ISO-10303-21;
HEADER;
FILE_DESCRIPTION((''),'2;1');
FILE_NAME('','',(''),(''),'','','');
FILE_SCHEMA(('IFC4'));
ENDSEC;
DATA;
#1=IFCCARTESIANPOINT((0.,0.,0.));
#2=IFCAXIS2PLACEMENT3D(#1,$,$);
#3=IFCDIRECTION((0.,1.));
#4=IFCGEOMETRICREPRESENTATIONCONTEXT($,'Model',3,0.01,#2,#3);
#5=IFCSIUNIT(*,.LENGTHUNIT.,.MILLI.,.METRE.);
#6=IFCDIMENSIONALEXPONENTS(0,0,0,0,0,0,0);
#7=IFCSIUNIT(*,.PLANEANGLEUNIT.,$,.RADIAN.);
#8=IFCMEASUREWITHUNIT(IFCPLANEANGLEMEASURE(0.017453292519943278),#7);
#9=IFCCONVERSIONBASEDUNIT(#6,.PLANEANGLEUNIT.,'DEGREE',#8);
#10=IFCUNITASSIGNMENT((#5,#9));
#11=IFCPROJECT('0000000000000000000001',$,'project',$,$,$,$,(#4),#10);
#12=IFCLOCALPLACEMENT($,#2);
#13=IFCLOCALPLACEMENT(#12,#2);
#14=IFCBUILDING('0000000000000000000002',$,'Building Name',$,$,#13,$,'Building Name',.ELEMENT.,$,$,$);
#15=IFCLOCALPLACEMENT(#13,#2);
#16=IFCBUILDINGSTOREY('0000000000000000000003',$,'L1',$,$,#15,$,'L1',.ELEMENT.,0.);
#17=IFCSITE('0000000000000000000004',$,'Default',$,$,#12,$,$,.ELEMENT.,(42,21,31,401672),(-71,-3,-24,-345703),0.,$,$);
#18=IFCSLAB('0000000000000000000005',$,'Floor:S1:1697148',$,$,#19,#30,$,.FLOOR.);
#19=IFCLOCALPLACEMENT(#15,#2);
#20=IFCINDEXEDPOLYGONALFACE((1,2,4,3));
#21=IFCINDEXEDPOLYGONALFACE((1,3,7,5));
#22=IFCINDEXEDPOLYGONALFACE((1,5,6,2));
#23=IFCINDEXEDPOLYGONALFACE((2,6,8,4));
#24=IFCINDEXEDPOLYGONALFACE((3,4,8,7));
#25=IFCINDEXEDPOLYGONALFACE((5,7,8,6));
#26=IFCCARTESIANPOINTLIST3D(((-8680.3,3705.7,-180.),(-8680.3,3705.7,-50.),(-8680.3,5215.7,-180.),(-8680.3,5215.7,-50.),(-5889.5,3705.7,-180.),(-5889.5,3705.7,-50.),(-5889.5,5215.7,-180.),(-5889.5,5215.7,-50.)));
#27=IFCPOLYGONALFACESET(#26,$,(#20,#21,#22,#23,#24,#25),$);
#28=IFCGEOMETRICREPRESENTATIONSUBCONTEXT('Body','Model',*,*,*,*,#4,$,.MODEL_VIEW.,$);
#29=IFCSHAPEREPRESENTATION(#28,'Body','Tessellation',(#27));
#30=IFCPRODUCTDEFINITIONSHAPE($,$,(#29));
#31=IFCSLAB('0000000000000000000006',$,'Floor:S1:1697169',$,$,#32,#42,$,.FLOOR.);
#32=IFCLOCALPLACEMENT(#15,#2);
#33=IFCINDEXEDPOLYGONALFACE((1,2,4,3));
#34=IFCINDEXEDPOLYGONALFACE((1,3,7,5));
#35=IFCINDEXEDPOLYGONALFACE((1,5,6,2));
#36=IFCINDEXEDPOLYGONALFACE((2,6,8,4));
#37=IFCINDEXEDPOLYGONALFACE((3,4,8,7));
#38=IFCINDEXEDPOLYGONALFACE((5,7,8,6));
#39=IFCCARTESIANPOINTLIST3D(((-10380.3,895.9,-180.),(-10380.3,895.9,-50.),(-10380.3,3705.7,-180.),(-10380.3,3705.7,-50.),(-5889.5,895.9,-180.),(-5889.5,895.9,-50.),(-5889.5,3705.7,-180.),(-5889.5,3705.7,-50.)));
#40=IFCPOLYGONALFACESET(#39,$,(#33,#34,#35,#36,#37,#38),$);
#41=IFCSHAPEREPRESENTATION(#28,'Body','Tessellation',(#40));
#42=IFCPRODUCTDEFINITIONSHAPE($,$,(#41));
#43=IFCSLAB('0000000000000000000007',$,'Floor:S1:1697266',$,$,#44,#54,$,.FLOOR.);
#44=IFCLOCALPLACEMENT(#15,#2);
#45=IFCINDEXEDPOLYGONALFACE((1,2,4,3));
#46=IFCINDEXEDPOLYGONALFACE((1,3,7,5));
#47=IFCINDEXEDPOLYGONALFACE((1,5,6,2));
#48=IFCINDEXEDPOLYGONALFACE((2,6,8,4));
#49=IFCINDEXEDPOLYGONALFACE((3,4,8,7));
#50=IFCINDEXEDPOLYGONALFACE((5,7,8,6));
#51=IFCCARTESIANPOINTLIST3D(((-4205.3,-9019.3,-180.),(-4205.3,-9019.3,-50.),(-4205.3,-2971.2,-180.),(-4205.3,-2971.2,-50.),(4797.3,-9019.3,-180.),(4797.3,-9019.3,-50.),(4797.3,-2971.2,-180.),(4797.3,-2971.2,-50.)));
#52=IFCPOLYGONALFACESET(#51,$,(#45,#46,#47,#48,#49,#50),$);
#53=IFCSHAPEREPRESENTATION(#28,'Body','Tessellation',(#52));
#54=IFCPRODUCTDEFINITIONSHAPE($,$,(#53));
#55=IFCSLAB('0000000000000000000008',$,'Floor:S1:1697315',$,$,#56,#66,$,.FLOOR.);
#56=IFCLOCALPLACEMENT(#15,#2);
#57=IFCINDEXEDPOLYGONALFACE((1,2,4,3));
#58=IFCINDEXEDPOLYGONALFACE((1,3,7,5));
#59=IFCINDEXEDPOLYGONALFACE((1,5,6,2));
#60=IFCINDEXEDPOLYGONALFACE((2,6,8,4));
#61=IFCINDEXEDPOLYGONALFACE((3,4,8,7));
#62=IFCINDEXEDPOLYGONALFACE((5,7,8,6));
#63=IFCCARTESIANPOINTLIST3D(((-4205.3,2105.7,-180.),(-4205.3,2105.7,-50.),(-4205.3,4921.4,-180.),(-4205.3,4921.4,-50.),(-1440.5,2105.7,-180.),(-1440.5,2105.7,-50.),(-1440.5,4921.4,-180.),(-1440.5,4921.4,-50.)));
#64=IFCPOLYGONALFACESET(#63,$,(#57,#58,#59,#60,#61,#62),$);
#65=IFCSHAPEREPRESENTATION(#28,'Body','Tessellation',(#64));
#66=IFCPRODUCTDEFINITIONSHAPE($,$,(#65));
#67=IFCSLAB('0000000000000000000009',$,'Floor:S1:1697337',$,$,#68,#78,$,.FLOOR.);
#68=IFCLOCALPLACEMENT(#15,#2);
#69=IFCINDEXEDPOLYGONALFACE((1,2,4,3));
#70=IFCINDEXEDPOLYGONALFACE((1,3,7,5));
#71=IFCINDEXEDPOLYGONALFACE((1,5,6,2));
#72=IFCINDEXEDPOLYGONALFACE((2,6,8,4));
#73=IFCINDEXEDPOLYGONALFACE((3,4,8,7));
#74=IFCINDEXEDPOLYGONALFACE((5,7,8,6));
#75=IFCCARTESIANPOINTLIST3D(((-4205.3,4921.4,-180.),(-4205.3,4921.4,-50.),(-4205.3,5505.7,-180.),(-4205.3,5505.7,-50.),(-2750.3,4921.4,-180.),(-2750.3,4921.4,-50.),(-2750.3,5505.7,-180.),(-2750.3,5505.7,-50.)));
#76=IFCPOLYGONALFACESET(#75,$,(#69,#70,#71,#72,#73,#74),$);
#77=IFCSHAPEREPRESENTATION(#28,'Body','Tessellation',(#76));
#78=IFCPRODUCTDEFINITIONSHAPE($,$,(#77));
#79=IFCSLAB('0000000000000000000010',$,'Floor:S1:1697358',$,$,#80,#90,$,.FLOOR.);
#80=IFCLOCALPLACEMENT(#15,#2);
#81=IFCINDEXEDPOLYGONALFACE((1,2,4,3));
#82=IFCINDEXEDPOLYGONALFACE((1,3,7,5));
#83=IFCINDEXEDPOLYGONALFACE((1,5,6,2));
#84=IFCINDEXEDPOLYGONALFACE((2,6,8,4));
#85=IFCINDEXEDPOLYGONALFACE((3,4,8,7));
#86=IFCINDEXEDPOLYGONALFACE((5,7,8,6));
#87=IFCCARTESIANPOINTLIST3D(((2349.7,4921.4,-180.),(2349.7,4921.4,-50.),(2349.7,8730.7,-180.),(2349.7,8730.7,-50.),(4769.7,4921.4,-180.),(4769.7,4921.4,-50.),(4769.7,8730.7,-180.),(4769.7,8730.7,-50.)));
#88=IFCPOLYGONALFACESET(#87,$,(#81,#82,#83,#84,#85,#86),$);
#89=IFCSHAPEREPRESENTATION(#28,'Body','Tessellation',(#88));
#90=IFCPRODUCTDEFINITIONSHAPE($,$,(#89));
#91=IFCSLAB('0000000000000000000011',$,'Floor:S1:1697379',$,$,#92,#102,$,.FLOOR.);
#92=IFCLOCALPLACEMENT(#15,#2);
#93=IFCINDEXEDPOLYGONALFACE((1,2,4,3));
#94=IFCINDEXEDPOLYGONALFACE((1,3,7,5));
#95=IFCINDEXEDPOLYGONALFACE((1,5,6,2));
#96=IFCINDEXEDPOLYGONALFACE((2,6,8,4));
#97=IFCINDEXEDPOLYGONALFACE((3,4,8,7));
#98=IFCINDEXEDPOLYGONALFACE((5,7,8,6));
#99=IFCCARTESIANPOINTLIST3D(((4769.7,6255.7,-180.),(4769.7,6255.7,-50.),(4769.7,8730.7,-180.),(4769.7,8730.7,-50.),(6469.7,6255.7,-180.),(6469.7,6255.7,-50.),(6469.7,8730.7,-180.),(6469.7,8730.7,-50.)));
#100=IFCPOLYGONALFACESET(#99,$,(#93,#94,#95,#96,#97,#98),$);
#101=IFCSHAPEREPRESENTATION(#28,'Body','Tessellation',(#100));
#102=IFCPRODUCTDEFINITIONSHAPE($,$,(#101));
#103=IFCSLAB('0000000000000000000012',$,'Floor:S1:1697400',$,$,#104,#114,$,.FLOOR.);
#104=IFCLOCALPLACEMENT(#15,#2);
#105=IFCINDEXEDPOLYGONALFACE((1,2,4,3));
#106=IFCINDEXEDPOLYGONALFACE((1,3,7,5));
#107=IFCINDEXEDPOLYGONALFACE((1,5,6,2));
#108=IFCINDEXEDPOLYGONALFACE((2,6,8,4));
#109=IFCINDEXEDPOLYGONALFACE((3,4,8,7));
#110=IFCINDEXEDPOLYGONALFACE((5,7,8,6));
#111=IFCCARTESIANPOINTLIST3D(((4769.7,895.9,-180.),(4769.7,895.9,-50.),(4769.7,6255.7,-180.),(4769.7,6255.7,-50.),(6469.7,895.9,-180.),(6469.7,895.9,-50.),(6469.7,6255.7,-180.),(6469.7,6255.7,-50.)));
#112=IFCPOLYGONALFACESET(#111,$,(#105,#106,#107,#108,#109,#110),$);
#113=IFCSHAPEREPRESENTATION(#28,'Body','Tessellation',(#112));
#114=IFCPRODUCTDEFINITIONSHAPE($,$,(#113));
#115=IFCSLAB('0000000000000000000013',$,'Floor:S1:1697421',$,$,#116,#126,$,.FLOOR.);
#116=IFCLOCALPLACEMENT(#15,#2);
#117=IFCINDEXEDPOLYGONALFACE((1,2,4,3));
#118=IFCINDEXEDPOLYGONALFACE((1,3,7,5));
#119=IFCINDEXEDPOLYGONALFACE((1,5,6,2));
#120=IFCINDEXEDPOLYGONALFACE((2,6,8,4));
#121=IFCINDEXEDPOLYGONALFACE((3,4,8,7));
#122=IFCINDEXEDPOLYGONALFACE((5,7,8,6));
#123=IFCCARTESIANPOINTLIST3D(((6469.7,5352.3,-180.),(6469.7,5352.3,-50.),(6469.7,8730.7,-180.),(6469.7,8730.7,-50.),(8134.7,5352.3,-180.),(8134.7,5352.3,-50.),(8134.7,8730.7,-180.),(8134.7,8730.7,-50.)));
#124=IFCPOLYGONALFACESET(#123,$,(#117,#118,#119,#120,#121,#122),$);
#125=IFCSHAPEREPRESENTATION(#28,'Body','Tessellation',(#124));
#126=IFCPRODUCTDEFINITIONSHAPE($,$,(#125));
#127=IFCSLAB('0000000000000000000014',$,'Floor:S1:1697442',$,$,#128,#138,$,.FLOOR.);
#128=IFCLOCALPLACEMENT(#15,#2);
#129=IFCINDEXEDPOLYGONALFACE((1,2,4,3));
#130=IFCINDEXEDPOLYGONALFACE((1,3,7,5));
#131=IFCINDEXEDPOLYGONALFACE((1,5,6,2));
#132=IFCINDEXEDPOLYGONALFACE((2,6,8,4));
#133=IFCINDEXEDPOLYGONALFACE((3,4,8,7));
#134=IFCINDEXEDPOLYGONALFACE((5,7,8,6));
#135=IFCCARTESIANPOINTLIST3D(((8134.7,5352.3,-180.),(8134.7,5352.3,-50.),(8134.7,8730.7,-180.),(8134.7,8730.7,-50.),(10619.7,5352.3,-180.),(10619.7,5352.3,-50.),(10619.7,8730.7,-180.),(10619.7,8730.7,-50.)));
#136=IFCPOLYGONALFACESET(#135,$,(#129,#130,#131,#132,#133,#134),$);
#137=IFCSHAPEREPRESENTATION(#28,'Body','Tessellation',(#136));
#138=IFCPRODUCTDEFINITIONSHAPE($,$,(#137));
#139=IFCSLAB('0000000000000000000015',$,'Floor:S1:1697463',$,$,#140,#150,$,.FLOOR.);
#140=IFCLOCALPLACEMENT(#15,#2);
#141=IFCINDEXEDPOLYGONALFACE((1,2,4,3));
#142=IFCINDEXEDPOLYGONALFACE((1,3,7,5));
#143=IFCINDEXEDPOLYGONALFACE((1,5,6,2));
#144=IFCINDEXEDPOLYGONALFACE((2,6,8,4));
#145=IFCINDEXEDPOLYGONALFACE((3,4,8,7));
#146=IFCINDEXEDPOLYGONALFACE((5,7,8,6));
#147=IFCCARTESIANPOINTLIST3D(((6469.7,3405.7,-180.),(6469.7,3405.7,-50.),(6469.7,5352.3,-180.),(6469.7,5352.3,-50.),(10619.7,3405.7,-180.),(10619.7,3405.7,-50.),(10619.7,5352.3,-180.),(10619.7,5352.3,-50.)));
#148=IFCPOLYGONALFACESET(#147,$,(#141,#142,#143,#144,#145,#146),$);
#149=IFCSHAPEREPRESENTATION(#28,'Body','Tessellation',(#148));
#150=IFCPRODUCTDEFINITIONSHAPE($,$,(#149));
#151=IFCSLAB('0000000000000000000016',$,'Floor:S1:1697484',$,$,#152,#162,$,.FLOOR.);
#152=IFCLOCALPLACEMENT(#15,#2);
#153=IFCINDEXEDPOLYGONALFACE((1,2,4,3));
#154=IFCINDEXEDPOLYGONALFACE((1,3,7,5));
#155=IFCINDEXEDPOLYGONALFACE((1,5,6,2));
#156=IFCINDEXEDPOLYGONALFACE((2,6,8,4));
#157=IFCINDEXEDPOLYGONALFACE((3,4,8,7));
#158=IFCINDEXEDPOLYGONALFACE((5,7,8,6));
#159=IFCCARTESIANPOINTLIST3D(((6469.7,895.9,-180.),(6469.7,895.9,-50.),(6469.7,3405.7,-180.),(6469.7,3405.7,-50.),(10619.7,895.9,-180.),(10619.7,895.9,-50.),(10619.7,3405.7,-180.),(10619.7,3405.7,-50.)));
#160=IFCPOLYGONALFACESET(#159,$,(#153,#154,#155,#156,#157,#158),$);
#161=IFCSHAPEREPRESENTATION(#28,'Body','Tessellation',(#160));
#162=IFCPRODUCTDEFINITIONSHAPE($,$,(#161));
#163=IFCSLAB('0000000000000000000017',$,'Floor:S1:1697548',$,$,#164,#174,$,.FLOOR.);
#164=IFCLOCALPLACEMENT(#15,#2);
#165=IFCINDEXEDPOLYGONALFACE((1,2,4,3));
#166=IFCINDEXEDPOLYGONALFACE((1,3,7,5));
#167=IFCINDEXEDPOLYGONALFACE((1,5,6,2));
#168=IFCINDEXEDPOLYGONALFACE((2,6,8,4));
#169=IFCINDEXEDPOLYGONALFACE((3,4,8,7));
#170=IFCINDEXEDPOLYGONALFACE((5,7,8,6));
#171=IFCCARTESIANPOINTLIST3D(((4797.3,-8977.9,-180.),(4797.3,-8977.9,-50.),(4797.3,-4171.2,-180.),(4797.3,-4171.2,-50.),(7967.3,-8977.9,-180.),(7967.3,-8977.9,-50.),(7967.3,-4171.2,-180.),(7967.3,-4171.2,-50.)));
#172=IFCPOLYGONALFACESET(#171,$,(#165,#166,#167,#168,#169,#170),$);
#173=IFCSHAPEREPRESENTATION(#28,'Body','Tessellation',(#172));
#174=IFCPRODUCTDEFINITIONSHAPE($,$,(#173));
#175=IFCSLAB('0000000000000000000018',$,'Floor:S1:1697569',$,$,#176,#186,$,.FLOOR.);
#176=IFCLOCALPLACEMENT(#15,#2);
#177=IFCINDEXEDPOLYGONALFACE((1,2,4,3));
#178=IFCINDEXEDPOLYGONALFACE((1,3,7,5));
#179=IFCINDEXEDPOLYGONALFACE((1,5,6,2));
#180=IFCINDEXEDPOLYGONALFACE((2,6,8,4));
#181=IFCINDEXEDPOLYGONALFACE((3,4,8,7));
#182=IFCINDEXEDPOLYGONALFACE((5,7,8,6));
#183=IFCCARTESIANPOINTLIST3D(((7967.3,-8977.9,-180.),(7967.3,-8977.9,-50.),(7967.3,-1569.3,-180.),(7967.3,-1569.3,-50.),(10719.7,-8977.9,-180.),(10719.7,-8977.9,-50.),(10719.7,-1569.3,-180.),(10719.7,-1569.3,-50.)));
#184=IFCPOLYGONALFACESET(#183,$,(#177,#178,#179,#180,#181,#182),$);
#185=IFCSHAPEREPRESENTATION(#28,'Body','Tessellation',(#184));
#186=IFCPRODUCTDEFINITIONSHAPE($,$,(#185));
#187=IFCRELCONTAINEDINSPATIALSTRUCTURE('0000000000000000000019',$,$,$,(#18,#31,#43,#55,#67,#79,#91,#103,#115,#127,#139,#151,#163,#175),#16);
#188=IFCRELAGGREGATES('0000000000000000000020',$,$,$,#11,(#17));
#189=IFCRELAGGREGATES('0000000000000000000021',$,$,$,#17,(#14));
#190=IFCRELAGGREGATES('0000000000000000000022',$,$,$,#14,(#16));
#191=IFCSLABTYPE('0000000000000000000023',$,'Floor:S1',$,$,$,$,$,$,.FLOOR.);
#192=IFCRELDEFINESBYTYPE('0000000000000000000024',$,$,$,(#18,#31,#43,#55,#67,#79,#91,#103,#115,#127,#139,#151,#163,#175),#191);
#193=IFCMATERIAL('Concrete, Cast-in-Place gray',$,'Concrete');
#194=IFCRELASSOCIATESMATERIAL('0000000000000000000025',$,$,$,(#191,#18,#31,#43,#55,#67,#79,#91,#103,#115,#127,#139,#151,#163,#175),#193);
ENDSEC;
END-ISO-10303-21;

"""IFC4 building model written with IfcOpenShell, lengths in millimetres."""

from ifc_helpers import new_model, entity, si_unit, converted_unit, direction, frame, origin, place, context, subcontext, project, spatial, indexed_curve, outline, extrude, material, type_object, element, save


model = new_model("IFC4")

# Units and contexts
model_context = context("Model", 3, precision=0.01, world=origin(), true_north=direction((0.0, 1.0)))
body_context = subcontext(model_context, "Body", "Model", "MODEL_VIEW")
ifc_project = project(units=[si_unit("LENGTHUNIT", "METRE", prefix="MILLI"), converted_unit("PLANEANGLEUNIT", "DEGREE", entity("IfcPlaneAngleMeasure", 0.017453292519943278), si_unit("PLANEANGLEUNIT", "RADIAN"), dimensions=[0, 0, 0, 0, 0, 0, 0])], contexts=[model_context])

# Site, building, storey
site_placement = place(None, origin())
site = spatial("IfcSite", under=ifc_project, at=site_placement, Name="Default", CompositionType="ELEMENT", RefLatitude=(42, 21, 31, 401672), RefLongitude=(-71, -3, -24, -345703), RefElevation=0.0)
building_placement = place(site_placement, origin())
building = spatial("IfcBuilding", under=site, at=building_placement, Name="Building Name", LongName="Building Name", CompositionType="ELEMENT")
storey_placement = place(building_placement, origin())
storey = spatial("IfcBuildingStorey", under=building, at=storey_placement, Name="L1", LongName="L1", CompositionType="ELEMENT", Elevation=0.0)

# Slabs
ifc_material = material(Name="Concrete, Cast-in-Place gray", Category="Concrete")
slab_type = type_object("IfcSlabType", Name="Floor:S1", PredefinedType="FLOOR", material=ifc_material)
slab_1_placement = place(storey_placement, origin())
element("IfcSlab", 1, at=slab_1_placement, inside=storey, type_object=slab_type, material=ifc_material, Name="Floor:S1:1697148", PredefinedType="FLOOR", context=body_context, shape_type="SweptSolid", body=[
    extrude(outline(indexed_curve([(-755.0, -1395.4), (755.0, -1395.4), (755.0, 1395.4), (-755.0, 1395.4), (-755.0, -1395.4)], self_intersect=False)), frame((-7284.9, 4460.7, -50.0), z_axis=(0.0, 0.0, -1.0), x_axis=(0.0, 1.0, 0.0)), (0.0, 0.0, 1.0), 130.0),
])
slab_2_placement = place(storey_placement, origin())
element("IfcSlab", 2, at=slab_2_placement, inside=storey, type_object=slab_type, material=ifc_material, Name="Floor:S1:1697169", PredefinedType="FLOOR", context=body_context, shape_type="SweptSolid", body=[
    extrude(outline(indexed_curve([(-1404.9, -2245.4), (1404.9, -2245.4), (1404.9, 2245.4), (-1404.9, 2245.4), (-1404.9, -2245.4)], self_intersect=False)), frame((-8134.9, 2300.8, -50.0), z_axis=(0.0, 0.0, -1.0), x_axis=(0.0, 1.0, 0.0)), (0.0, 0.0, 1.0), 130.0),
])
slab_3_placement = place(storey_placement, origin())
element("IfcSlab", 3, at=slab_3_placement, inside=storey, type_object=slab_type, material=ifc_material, Name="Floor:S1:1697266", PredefinedType="FLOOR", context=body_context, shape_type="SweptSolid", body=[
    extrude(outline(indexed_curve([(-3024.1, -4501.3), (3024.1, -4501.3), (3024.1, 4501.3), (-3024.1, 4501.3), (-3024.1, -4501.3)], self_intersect=False)), frame((296.0, -5995.3, -50.0), z_axis=(0.0, 0.0, -1.0), x_axis=(0.0, 1.0, 0.0)), (0.0, 0.0, 1.0), 130.0),
])
slab_4_placement = place(storey_placement, origin())
element("IfcSlab", 4, at=slab_4_placement, inside=storey, type_object=slab_type, material=ifc_material, Name="Floor:S1:1697315", PredefinedType="FLOOR", context=body_context, shape_type="SweptSolid", body=[
    extrude(outline(indexed_curve([(-1407.9, -1382.4), (1407.9, -1382.4), (1407.9, 1382.4), (-1407.9, 1382.4), (-1407.9, -1382.4)], self_intersect=False)), frame((-2822.9, 3513.6, -50.0), z_axis=(0.0, 0.0, -1.0), x_axis=(0.0, 1.0, 0.0)), (0.0, 0.0, 1.0), 130.0),
])
slab_5_placement = place(storey_placement, origin())
element("IfcSlab", 5, at=slab_5_placement, inside=storey, type_object=slab_type, material=ifc_material, Name="Floor:S1:1697337", PredefinedType="FLOOR", context=body_context, shape_type="SweptSolid", body=[
    extrude(outline(indexed_curve([(-292.1, -727.5), (292.1, -727.5), (292.1, 727.5), (-292.1, 727.5), (-292.1, -727.5)], self_intersect=False)), frame((-3477.8, 5213.6, -50.0), z_axis=(0.0, 0.0, -1.0), x_axis=(0.0, 1.0, 0.0)), (0.0, 0.0, 1.0), 130.0),
])
slab_6_placement = place(storey_placement, origin())
element("IfcSlab", 6, at=slab_6_placement, inside=storey, type_object=slab_type, material=ifc_material, Name="Floor:S1:1697358", PredefinedType="FLOOR", context=body_context, shape_type="SweptSolid", body=[
    extrude(outline(indexed_curve([(-1904.6, -1210.0), (1904.6, -1210.0), (1904.6, 1210.0), (-1904.6, 1210.0), (-1904.6, -1210.0)], self_intersect=False)), frame((3559.7, 6826.1, -50.0), z_axis=(0.0, 0.0, -1.0), x_axis=(0.0, 1.0, 0.0)), (0.0, 0.0, 1.0), 130.0),
])
slab_7_placement = place(storey_placement, origin())
element("IfcSlab", 7, at=slab_7_placement, inside=storey, type_object=slab_type, material=ifc_material, Name="Floor:S1:1697379", PredefinedType="FLOOR", context=body_context, shape_type="SweptSolid", body=[
    extrude(outline(indexed_curve([(-1237.5, -850.0), (1237.5, -850.0), (1237.5, 850.0), (-1237.5, 850.0), (-1237.5, -850.0)], self_intersect=False)), frame((5619.7, 7493.2, -50.0), z_axis=(0.0, 0.0, -1.0), x_axis=(0.0, 1.0, 0.0)), (0.0, 0.0, 1.0), 130.0),
])
slab_8_placement = place(storey_placement, origin())
element("IfcSlab", 8, at=slab_8_placement, inside=storey, type_object=slab_type, material=ifc_material, Name="Floor:S1:1697400", PredefinedType="FLOOR", context=body_context, shape_type="SweptSolid", body=[
    extrude(outline(indexed_curve([(-2679.9, -850.0), (2679.9, -850.0), (2679.9, 850.0), (-2679.9, 850.0), (-2679.9, -850.0)], self_intersect=False)), frame((5619.7, 3575.8, -50.0), z_axis=(0.0, 0.0, -1.0), x_axis=(0.0, 1.0, 0.0)), (0.0, 0.0, 1.0), 130.0),
])
slab_9_placement = place(storey_placement, origin())
element("IfcSlab", 9, at=slab_9_placement, inside=storey, type_object=slab_type, material=ifc_material, Name="Floor:S1:1697421", PredefinedType="FLOOR", context=body_context, shape_type="SweptSolid", body=[
    extrude(outline(indexed_curve([(-1689.2, -832.5), (1689.2, -832.5), (1689.2, 832.5), (-1689.2, 832.5), (-1689.2, -832.5)], self_intersect=False)), frame((7302.2, 7041.5, -50.0), z_axis=(0.0, 0.0, -1.0), x_axis=(0.0, 1.0, 0.0)), (0.0, 0.0, 1.0), 130.0),
])
slab_10_placement = place(storey_placement, origin())
element("IfcSlab", 10, at=slab_10_placement, inside=storey, type_object=slab_type, material=ifc_material, Name="Floor:S1:1697442", PredefinedType="FLOOR", context=body_context, shape_type="SweptSolid", body=[
    extrude(outline(indexed_curve([(-1689.2, -1242.5), (1689.2, -1242.5), (1689.2, 1242.5), (-1689.2, 1242.5), (-1689.2, -1242.5)], self_intersect=False)), frame((9377.2, 7041.5, -50.0), z_axis=(0.0, 0.0, -1.0), x_axis=(0.0, 1.0, 0.0)), (0.0, 0.0, 1.0), 130.0),
])
slab_11_placement = place(storey_placement, origin())
element("IfcSlab", 11, at=slab_11_placement, inside=storey, type_object=slab_type, material=ifc_material, Name="Floor:S1:1697463", PredefinedType="FLOOR", context=body_context, shape_type="SweptSolid", body=[
    extrude(outline(indexed_curve([(-973.3, -2075.0), (973.3, -2075.0), (973.3, 2075.0), (-973.3, 2075.0), (-973.3, -2075.0)], self_intersect=False)), frame((8544.7, 4379.0, -50.0), z_axis=(0.0, 0.0, -1.0), x_axis=(0.0, 1.0, 0.0)), (0.0, 0.0, 1.0), 130.0),
])
slab_12_placement = place(storey_placement, origin())
element("IfcSlab", 12, at=slab_12_placement, inside=storey, type_object=slab_type, material=ifc_material, Name="Floor:S1:1697484", PredefinedType="FLOOR", context=body_context, shape_type="SweptSolid", body=[
    extrude(outline(indexed_curve([(-1254.9, -2075.0), (1254.9, -2075.0), (1254.9, 2075.0), (-1254.9, 2075.0), (-1254.9, -2075.0)], self_intersect=False)), frame((8544.7, 2150.8, -50.0), z_axis=(0.0, 0.0, -1.0), x_axis=(0.0, 1.0, 0.0)), (0.0, 0.0, 1.0), 130.0),
])
slab_13_placement = place(storey_placement, origin())
element("IfcSlab", 13, at=slab_13_placement, inside=storey, type_object=slab_type, material=ifc_material, Name="Floor:S1:1697548", PredefinedType="FLOOR", context=body_context, shape_type="SweptSolid", body=[
    extrude(outline(indexed_curve([(-2403.4, -1585.0), (2403.4, -1585.0), (2403.4, 1585.0), (-2403.4, 1585.0), (-2403.4, -1585.0)], self_intersect=False)), frame((6382.3, -6574.5, -50.0), z_axis=(0.0, 0.0, -1.0), x_axis=(0.0, 1.0, 0.0)), (0.0, 0.0, 1.0), 130.0),
])
slab_14_placement = place(storey_placement, origin())
element("IfcSlab", 14, at=slab_14_placement, inside=storey, type_object=slab_type, material=ifc_material, Name="Floor:S1:1697569", PredefinedType="FLOOR", context=body_context, shape_type="SweptSolid", body=[
    extrude(outline(indexed_curve([(-3704.3, -1376.2), (3704.3, -1376.2), (3704.3, 1376.2), (-3704.3, 1376.2), (-3704.3, -1376.2)], self_intersect=False)), frame((9343.5, -5273.6, -50.0), z_axis=(0.0, 0.0, -1.0), x_axis=(0.0, 1.0, 0.0)), (0.0, 0.0, 1.0), 130.0),
])

save(model, "model.ifc")
